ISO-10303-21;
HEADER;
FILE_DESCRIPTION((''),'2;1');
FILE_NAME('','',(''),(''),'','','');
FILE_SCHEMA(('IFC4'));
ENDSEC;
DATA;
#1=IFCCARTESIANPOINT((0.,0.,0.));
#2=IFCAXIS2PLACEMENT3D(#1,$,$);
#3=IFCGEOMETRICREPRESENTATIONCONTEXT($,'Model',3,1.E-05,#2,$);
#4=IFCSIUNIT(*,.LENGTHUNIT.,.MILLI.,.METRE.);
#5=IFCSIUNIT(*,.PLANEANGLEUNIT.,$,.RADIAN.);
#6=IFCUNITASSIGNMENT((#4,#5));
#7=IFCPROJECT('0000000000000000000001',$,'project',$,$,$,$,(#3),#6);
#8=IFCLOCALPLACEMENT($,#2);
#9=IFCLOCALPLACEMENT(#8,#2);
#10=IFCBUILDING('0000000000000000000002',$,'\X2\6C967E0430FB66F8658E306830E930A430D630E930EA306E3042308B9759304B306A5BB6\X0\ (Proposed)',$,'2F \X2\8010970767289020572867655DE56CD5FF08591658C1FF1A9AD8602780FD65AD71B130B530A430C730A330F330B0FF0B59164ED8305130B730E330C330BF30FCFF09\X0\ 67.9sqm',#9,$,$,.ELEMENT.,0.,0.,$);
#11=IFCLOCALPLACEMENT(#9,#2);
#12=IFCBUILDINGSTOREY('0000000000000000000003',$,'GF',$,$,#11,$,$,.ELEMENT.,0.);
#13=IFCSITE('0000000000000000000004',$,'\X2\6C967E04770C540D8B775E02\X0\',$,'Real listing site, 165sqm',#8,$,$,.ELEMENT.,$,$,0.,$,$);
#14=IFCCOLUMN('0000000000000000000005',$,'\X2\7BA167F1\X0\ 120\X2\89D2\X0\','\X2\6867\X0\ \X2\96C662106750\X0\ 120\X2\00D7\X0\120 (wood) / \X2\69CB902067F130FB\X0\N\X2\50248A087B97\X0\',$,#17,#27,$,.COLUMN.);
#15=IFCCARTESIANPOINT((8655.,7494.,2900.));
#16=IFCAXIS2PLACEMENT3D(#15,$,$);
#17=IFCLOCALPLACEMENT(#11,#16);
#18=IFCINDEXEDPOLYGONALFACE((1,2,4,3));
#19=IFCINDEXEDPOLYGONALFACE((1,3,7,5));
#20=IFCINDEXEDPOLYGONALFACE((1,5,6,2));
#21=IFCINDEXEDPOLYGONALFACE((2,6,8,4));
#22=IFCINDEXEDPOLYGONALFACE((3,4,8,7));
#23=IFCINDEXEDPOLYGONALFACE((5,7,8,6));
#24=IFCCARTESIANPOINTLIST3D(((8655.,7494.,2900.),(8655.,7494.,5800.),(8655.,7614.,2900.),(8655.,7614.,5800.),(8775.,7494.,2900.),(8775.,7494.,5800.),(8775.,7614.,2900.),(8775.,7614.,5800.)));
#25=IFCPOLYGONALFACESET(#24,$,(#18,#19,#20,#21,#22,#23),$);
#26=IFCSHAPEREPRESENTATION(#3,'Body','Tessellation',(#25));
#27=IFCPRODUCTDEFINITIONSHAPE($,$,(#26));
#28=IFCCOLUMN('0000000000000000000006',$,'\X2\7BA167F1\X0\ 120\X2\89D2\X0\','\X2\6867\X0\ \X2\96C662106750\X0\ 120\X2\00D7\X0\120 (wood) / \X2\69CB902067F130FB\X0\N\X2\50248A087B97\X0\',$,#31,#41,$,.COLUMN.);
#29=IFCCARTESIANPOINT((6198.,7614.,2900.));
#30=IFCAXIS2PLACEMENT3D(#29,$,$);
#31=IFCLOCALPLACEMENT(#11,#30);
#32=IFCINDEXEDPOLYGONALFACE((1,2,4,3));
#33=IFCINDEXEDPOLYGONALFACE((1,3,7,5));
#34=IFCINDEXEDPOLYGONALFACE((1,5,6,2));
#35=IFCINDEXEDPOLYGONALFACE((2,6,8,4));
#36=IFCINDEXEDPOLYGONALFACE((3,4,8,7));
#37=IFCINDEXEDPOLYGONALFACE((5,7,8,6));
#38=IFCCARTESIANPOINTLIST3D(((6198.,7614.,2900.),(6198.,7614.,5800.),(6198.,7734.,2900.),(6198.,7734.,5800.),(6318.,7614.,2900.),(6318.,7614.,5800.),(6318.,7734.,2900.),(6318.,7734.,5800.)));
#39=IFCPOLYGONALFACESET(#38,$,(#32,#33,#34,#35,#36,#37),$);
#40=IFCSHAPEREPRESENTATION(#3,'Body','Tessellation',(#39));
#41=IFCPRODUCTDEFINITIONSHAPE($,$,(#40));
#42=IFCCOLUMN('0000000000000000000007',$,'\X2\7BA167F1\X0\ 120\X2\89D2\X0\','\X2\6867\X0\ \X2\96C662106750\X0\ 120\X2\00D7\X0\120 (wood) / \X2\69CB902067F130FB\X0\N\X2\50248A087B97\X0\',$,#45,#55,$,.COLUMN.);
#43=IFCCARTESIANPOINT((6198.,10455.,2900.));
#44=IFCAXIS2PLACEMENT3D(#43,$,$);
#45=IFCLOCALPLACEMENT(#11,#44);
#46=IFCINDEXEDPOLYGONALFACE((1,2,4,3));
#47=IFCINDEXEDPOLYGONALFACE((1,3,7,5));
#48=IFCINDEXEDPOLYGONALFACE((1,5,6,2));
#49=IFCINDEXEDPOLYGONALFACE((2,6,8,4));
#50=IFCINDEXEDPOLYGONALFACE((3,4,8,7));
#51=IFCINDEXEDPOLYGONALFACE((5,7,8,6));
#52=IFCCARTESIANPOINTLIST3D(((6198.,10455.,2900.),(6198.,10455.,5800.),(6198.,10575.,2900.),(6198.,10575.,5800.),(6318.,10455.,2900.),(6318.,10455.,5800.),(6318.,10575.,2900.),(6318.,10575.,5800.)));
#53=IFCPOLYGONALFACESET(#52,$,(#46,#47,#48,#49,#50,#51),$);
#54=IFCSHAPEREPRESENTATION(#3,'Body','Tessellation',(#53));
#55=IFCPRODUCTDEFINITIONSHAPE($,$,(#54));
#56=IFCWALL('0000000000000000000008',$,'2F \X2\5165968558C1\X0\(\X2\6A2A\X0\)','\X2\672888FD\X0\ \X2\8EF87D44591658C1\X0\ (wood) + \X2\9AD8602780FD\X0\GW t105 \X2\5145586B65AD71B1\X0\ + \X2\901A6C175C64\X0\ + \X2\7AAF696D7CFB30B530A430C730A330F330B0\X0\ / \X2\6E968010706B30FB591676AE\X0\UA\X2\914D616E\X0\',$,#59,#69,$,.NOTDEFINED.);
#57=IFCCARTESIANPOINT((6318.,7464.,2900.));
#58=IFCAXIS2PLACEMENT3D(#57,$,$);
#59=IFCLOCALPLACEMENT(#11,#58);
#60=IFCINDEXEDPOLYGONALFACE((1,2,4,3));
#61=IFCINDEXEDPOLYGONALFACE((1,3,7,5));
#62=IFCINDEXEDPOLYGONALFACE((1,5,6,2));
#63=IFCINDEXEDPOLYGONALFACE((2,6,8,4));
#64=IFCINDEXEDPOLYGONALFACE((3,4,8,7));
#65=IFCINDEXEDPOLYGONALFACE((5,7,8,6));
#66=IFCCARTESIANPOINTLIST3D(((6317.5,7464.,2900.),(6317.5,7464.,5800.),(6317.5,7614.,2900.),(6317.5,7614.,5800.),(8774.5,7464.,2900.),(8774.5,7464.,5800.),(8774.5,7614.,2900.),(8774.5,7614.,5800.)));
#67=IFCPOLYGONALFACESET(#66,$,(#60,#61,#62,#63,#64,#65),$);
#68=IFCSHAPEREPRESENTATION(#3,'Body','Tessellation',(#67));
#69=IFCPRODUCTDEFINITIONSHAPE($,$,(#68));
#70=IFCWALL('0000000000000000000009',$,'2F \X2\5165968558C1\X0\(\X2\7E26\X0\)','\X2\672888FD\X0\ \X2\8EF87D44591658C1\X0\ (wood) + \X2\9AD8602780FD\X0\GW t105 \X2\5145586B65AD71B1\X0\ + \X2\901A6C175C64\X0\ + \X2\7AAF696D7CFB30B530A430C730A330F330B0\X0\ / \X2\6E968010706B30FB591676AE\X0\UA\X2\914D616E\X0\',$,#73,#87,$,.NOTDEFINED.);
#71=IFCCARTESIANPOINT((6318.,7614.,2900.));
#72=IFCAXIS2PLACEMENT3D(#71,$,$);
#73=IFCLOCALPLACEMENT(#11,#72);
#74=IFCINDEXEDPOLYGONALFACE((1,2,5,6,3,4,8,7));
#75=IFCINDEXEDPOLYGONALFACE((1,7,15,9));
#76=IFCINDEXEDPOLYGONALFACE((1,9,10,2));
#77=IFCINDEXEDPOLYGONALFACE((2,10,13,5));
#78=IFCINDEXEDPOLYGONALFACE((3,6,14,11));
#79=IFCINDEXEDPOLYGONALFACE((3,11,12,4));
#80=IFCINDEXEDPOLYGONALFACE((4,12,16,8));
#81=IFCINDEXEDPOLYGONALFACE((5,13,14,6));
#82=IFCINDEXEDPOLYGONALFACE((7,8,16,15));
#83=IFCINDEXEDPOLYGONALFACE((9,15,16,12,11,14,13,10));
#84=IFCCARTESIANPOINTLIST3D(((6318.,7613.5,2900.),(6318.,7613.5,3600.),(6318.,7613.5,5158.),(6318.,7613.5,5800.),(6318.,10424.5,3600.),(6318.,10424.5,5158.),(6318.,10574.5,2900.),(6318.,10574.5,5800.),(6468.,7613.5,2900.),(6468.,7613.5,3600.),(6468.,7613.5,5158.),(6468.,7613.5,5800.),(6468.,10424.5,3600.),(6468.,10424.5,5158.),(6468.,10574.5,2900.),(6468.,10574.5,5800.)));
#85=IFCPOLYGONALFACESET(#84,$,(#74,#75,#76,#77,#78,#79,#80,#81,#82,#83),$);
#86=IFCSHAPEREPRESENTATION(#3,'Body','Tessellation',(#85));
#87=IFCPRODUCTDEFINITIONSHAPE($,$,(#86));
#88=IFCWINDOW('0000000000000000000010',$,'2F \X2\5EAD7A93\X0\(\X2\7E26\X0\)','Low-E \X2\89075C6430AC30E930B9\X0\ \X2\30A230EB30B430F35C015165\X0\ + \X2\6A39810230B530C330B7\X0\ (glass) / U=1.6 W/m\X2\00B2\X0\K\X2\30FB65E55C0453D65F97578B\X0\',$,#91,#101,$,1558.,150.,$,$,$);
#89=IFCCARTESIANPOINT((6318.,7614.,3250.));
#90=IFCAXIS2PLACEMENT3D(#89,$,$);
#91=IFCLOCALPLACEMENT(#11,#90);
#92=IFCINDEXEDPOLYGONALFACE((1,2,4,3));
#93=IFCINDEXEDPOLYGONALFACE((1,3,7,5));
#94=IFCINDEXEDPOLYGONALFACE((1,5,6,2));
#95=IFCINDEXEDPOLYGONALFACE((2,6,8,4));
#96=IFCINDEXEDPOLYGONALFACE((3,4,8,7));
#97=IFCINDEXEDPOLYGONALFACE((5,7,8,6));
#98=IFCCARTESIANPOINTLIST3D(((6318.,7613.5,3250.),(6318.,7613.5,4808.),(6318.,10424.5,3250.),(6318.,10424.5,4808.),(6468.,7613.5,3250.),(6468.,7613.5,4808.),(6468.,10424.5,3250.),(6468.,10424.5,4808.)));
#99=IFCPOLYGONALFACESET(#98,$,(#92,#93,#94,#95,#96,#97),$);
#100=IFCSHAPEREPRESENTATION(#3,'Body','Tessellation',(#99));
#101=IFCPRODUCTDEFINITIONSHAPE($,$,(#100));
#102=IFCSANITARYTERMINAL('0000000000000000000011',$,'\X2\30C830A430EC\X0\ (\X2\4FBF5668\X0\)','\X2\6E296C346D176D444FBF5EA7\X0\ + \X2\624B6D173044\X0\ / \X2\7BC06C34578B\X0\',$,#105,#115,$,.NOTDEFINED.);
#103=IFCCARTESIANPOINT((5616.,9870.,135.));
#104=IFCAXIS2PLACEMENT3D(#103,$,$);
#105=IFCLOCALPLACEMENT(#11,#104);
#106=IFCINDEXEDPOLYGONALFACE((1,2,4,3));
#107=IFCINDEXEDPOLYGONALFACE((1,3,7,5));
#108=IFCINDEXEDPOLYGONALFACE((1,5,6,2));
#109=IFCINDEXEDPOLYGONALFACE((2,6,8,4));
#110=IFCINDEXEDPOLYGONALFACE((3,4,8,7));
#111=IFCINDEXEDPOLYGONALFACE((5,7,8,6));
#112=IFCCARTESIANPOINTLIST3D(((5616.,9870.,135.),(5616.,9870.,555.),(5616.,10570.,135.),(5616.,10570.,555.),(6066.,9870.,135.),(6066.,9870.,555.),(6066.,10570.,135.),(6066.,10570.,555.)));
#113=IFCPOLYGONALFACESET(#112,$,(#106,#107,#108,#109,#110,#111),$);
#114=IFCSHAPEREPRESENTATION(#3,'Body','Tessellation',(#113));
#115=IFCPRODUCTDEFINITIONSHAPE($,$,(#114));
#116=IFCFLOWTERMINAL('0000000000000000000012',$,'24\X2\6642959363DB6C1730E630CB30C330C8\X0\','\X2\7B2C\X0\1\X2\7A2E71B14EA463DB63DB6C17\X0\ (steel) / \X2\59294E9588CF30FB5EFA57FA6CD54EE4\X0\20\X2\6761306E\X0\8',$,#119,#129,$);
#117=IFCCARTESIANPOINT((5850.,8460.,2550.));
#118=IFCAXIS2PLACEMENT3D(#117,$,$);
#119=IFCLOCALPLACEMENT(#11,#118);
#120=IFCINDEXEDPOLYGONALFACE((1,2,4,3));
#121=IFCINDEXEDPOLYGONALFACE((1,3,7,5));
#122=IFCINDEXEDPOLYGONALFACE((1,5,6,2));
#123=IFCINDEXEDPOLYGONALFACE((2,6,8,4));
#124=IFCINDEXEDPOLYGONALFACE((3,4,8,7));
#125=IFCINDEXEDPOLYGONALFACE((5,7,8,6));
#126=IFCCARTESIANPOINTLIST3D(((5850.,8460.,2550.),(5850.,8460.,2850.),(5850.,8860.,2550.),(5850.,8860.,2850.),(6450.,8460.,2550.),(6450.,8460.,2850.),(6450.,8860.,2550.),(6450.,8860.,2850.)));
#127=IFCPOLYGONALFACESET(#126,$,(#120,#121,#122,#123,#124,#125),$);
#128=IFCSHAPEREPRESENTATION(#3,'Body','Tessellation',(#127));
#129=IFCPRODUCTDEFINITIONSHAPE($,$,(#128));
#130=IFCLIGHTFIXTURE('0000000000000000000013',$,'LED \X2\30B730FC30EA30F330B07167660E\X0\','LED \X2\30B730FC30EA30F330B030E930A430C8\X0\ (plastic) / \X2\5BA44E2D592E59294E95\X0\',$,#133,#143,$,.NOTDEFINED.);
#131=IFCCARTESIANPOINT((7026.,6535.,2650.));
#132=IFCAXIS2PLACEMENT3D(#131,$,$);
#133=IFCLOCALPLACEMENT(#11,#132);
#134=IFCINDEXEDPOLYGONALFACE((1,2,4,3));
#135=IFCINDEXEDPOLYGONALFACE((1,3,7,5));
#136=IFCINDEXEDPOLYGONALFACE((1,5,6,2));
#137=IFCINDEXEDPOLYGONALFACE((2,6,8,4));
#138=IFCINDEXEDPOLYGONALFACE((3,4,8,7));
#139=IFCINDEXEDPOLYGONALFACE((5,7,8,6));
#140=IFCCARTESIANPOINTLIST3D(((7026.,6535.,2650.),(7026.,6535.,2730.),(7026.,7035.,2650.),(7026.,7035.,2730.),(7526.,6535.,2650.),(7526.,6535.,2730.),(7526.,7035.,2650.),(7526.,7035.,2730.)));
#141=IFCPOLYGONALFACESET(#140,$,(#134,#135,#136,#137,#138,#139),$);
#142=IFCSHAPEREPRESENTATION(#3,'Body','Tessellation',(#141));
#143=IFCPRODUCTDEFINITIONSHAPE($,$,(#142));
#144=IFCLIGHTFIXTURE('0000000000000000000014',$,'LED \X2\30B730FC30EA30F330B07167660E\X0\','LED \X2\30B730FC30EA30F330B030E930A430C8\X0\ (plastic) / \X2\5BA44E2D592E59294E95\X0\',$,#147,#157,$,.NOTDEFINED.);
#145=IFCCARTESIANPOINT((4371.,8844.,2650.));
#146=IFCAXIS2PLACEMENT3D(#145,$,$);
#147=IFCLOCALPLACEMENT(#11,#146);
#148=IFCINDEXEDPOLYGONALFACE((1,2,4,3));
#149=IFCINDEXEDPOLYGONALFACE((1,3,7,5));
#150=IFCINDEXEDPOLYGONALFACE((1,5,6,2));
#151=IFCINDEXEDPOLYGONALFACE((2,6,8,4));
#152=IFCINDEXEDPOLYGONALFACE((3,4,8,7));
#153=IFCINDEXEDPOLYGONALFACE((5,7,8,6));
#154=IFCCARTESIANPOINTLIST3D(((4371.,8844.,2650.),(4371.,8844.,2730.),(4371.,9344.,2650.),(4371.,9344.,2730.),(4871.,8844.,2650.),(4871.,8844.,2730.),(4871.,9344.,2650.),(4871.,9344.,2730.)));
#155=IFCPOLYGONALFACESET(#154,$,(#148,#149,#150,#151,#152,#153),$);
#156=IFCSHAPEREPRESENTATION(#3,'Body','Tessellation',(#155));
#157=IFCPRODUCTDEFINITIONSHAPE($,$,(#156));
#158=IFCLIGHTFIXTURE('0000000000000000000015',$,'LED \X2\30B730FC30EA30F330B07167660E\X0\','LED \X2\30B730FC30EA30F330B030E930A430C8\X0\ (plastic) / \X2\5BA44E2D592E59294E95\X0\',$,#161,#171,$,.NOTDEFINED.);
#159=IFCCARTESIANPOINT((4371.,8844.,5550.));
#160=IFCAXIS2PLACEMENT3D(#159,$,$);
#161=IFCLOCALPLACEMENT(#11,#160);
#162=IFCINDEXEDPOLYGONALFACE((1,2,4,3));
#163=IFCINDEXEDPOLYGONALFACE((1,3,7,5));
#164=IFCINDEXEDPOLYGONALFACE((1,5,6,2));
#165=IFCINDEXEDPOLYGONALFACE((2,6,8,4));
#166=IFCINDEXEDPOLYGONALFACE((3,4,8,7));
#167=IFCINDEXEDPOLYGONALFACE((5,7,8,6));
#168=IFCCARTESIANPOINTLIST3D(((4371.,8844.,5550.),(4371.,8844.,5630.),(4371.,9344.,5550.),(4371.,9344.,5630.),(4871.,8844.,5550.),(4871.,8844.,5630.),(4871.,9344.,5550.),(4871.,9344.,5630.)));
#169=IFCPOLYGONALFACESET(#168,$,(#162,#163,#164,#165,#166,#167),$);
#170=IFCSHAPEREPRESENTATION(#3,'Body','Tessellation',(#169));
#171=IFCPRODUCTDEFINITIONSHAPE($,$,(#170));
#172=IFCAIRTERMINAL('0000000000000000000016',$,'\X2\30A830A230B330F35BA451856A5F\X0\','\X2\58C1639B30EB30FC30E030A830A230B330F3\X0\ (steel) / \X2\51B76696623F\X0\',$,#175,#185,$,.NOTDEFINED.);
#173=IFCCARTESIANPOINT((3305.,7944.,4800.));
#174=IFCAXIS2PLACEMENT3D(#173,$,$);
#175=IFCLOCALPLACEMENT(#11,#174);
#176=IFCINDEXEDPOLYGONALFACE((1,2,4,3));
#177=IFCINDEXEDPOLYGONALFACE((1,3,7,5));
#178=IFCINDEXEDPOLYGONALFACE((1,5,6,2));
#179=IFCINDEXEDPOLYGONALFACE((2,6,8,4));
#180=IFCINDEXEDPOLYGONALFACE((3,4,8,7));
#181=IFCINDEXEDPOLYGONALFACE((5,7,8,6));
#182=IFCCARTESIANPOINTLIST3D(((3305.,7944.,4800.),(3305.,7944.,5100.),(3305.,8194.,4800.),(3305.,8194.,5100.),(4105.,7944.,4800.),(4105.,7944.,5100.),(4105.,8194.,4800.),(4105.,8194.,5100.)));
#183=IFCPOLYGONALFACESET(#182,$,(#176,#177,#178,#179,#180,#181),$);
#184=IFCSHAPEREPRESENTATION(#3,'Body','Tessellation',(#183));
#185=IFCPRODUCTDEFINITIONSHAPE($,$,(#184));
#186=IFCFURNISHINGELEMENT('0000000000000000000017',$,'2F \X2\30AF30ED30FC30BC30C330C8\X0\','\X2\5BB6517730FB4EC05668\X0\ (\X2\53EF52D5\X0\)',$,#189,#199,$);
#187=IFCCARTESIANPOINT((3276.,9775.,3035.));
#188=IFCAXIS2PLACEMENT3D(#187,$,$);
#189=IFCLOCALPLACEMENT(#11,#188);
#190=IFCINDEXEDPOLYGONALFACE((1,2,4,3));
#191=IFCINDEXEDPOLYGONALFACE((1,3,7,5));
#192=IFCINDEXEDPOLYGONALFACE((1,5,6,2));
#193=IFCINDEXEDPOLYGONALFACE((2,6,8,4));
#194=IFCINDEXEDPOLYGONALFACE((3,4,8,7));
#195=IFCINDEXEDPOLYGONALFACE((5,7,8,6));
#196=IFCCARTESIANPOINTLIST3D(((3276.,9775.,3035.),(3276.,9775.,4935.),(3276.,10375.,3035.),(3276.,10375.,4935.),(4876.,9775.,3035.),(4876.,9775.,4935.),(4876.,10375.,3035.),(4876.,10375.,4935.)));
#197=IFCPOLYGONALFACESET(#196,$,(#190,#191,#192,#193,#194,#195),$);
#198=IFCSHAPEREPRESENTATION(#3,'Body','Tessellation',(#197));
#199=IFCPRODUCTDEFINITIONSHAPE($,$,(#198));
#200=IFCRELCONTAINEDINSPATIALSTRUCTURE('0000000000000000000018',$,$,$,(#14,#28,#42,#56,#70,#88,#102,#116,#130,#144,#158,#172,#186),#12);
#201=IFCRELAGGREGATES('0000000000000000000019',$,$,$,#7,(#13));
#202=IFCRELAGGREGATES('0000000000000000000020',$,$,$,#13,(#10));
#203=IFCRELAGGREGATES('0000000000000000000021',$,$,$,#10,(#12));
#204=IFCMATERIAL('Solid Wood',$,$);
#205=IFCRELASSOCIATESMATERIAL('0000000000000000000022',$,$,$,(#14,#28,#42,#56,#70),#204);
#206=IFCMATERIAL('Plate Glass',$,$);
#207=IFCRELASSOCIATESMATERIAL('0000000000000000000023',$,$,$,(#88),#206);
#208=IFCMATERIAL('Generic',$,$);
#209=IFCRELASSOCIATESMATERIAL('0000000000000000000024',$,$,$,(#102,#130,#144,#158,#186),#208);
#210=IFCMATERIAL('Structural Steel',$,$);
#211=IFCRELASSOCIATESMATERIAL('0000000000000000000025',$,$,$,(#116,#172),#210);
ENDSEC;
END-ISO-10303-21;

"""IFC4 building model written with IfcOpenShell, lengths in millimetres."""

from ifc_helpers import new_model, si_unit, frame, frame_2d, origin, place, context, project, spatial, rectangle, extrude, material, element, fill, save


model = new_model("IFC4")

# Units and contexts
model_context = context("Model", 3, precision=1e-05, world=origin())
ifc_project = project(units=[si_unit("LENGTHUNIT", "METRE", prefix="MILLI"), si_unit("PLANEANGLEUNIT", "RADIAN")], contexts=[model_context])

# Site, building, storey
site_placement = place(None, origin())
site = spatial("IfcSite", under=ifc_project, at=site_placement, Name="沖縄県名護市", ObjectType="Real listing site, 165sqm", CompositionType="ELEMENT", RefElevation=0.0)
building_placement = place(site_placement, origin())
building = spatial("IfcBuilding", under=site, at=building_placement, Name="沖縄・書斎とライブラリのある静かな家 (Proposed)", ObjectType="2F 耐震木造在来工法（外壁：高性能断熱サイディング＋外付けシャッター） 67.9sqm", CompositionType="ELEMENT", ElevationOfRefHeight=0.0, ElevationOfTerrain=0.0)
storey_placement = place(building_placement, origin())
storey = spatial("IfcBuildingStorey", under=building, at=storey_placement, Name="GF", CompositionType="ELEMENT", Elevation=0.0)

# Columns
ifc_material_1 = material(Name="Solid Wood")
column_1_placement = place(storey_placement, frame((8655.0, 7494.0, 2900.0)))
element("IfcColumn", 1, at=column_1_placement, inside=storey, material=ifc_material_1, Name="管柱 120角", Description="桧 集成材 120×120 (wood) / 構造柱・N値計算", PredefinedType="COLUMN", context=model_context, shape_type="SweptSolid", body=[
    extrude(rectangle(XDim=120.0, YDim=120.0, at=frame_2d((60.0, 60.0))), frame((8655.0, 7494.0, 2900.0)), (0.0, 0.0, 1.0), 2900.0),
])
column_2_placement = place(storey_placement, frame((6198.0, 7614.0, 2900.0)))
element("IfcColumn", 2, at=column_2_placement, inside=storey, material=ifc_material_1, Name="管柱 120角", Description="桧 集成材 120×120 (wood) / 構造柱・N値計算", PredefinedType="COLUMN", context=model_context, shape_type="SweptSolid", body=[
    extrude(rectangle(XDim=120.0, YDim=120.0, at=frame_2d((60.0, 60.0))), frame((6198.0, 7614.0, 2900.0)), (0.0, 0.0, 1.0), 2900.0),
])
column_3_placement = place(storey_placement, frame((6198.0, 10455.0, 2900.0)))
element("IfcColumn", 3, at=column_3_placement, inside=storey, material=ifc_material_1, Name="管柱 120角", Description="桧 集成材 120×120 (wood) / 構造柱・N値計算", PredefinedType="COLUMN", context=model_context, shape_type="SweptSolid", body=[
    extrude(rectangle(XDim=120.0, YDim=120.0, at=frame_2d((60.0, 60.0))), frame((6198.0, 10455.0, 2900.0)), (0.0, 0.0, 1.0), 2900.0),
])

# Wall
wall_1_placement = place(storey_placement, frame((6318.0, 7464.0, 2900.0)))
element("IfcWall", 4, at=wall_1_placement, inside=storey, material=ifc_material_1, Name="2F 入隅壁(横)", Description="木製 軸組外壁 (wood) + 高性能GW t105 充填断熱 + 通気層 + 窯業系サイディング / 準耐火・外皮UA配慮", PredefinedType="NOTDEFINED", context=model_context, shape_type="SweptSolid", body=[
    extrude(rectangle(XDim=2457.0, YDim=150.0, at=frame_2d((1228.0, 75.0))), frame((6318.0, 7464.0, 2900.0)), (0.0, 0.0, 1.0), 2900.0),
])

# Wall, opening, window
wall_2_placement = place(storey_placement, frame((6318.0, 7614.0, 2900.0)))
wall_2 = element("IfcWall", 5, at=wall_2_placement, inside=storey, material=ifc_material_1, Name="2F 入隅壁(縦)", Description="木製 軸組外壁 (wood) + 高性能GW t105 充填断熱 + 通気層 + 窯業系サイディング / 準耐火・外皮UA配慮", PredefinedType="NOTDEFINED", context=model_context, shape_type="SweptSolid", body=[
    extrude(rectangle(XDim=150.0, YDim=2961.0, at=frame_2d((75.0, 1480.0))), frame((6318.0, 7614.0, 2900.0)), (0.0, 0.0, 1.0), 2900.0),
])
opening_placement = place(storey_placement, frame((6318.0, 7614.0, 3250.0)))
opening = element("IfcOpeningElement", 6, at=opening_placement, cuts=wall_2, PredefinedType="NOTDEFINED", context=model_context, shape_type="SweptSolid", body=[
    extrude(rectangle(XDim=150.0, YDim=2811.0, at=frame_2d((75.0, 1405.0))), frame((6318.0, 7614.0, 3250.0)), (0.0, 0.0, 1.0), 1558.0),
])
ifc_material_2 = material(Name="Plate Glass")
window_placement = place(storey_placement, frame((6318.0, 7614.0, 3250.0)))
window = element("IfcWindow", 7, at=window_placement, inside=storey, material=ifc_material_2, Name="2F 庭窓(縦)", Description="Low-E 複層ガラス アルゴン封入 + 樹脂サッシ (glass) / U=1.6 W/m²K・日射取得型", OverallHeight=1558.0, OverallWidth=150.0, context=model_context, shape_type="SweptSolid", body=[
    extrude(rectangle(XDim=150.0, YDim=2811.0, at=frame_2d((75.0, 1405.0))), frame((6318.0, 7614.0, 3250.0)), (0.0, 0.0, 1.0), 1558.0),
])
fill(opening, window)

# Sanitary terminal
ifc_material_3 = material(Name="Generic")
sanitary_terminal_placement = place(storey_placement, frame((5616.0, 9870.0, 135.0)))
element("IfcSanitaryTerminal", 8, at=sanitary_terminal_placement, inside=storey, material=ifc_material_3, Name="トイレ (便器)", Description="温水洗浄便座 + 手洗い / 節水型", PredefinedType="NOTDEFINED", context=model_context, shape_type="SweptSolid", body=[
    extrude(rectangle(XDim=450.0, YDim=700.0, at=frame_2d((225.0, 350.0))), frame((5616.0, 9870.0, 135.0)), (0.0, 0.0, 1.0), 420.0),
])

# Flow terminal
ifc_material_4 = material(Name="Structural Steel")
flow_terminal_placement = place(storey_placement, frame((5850.0, 8460.0, 2550.0)))
element("IfcFlowTerminal", 9, at=flow_terminal_placement, inside=storey, material=ifc_material_4, Name="24時間換気ユニット", Description="第1種熱交換換気 (steel) / 天井裏・建基法令20条の8", context=model_context, shape_type="SweptSolid", body=[
    extrude(rectangle(XDim=600.0, YDim=400.0, at=frame_2d((300.0, 200.0))), frame((5850.0, 8460.0, 2550.0)), (0.0, 0.0, 1.0), 300.0),
])

# Light fixtures
light_fixture_1_placement = place(storey_placement, frame((7026.0, 6535.0, 2650.0)))
element("IfcLightFixture", 10, at=light_fixture_1_placement, inside=storey, material=ifc_material_3, Name="LED シーリング照明", Description="LED シーリングライト (plastic) / 室中央天井", PredefinedType="NOTDEFINED", context=model_context, shape_type="SweptSolid", body=[
    extrude(rectangle(XDim=500.0, YDim=500.0, at=frame_2d((250.0, 250.0))), frame((7026.0, 6535.0, 2650.0)), (0.0, 0.0, 1.0), 80.0),
])
light_fixture_2_placement = place(storey_placement, frame((4371.0, 8844.0, 2650.0)))
element("IfcLightFixture", 11, at=light_fixture_2_placement, inside=storey, material=ifc_material_3, Name="LED シーリング照明", Description="LED シーリングライト (plastic) / 室中央天井", PredefinedType="NOTDEFINED", context=model_context, shape_type="SweptSolid", body=[
    extrude(rectangle(XDim=500.0, YDim=500.0, at=frame_2d((250.0, 250.0))), frame((4371.0, 8844.0, 2650.0)), (0.0, 0.0, 1.0), 80.0),
])
light_fixture_3_placement = place(storey_placement, frame((4371.0, 8844.0, 5550.0)))
element("IfcLightFixture", 12, at=light_fixture_3_placement, inside=storey, material=ifc_material_3, Name="LED シーリング照明", Description="LED シーリングライト (plastic) / 室中央天井", PredefinedType="NOTDEFINED", context=model_context, shape_type="SweptSolid", body=[
    extrude(rectangle(XDim=500.0, YDim=500.0, at=frame_2d((250.0, 250.0))), frame((4371.0, 8844.0, 5550.0)), (0.0, 0.0, 1.0), 80.0),
])

# Air terminal
air_terminal_placement = place(storey_placement, frame((3305.0, 7944.0, 4800.0)))
element("IfcAirTerminal", 13, at=air_terminal_placement, inside=storey, material=ifc_material_4, Name="エアコン室内機", Description="壁掛ルームエアコン (steel) / 冷暖房", PredefinedType="NOTDEFINED", context=model_context, shape_type="SweptSolid", body=[
    extrude(rectangle(XDim=800.0, YDim=250.0, at=frame_2d((400.0, 125.0))), frame((3305.0, 7944.0, 4800.0)), (0.0, 0.0, 1.0), 300.0),
])

# Furnishing element
furnishing_1_placement = place(storey_placement, frame((3276.0, 9775.0, 3035.0)))
element("IfcFurnishingElement", 14, at=furnishing_1_placement, inside=storey, material=ifc_material_3, Name="2F クローゼット", Description="家具・什器 (可動)", context=model_context, shape_type="SweptSolid", body=[
    extrude(rectangle(XDim=1600.0, YDim=600.0, at=frame_2d((800.0, 300.0))), frame((3276.0, 9775.0, 3035.0)), (0.0, 0.0, 1.0), 1900.0),
])

save(model, "model.ifc")
